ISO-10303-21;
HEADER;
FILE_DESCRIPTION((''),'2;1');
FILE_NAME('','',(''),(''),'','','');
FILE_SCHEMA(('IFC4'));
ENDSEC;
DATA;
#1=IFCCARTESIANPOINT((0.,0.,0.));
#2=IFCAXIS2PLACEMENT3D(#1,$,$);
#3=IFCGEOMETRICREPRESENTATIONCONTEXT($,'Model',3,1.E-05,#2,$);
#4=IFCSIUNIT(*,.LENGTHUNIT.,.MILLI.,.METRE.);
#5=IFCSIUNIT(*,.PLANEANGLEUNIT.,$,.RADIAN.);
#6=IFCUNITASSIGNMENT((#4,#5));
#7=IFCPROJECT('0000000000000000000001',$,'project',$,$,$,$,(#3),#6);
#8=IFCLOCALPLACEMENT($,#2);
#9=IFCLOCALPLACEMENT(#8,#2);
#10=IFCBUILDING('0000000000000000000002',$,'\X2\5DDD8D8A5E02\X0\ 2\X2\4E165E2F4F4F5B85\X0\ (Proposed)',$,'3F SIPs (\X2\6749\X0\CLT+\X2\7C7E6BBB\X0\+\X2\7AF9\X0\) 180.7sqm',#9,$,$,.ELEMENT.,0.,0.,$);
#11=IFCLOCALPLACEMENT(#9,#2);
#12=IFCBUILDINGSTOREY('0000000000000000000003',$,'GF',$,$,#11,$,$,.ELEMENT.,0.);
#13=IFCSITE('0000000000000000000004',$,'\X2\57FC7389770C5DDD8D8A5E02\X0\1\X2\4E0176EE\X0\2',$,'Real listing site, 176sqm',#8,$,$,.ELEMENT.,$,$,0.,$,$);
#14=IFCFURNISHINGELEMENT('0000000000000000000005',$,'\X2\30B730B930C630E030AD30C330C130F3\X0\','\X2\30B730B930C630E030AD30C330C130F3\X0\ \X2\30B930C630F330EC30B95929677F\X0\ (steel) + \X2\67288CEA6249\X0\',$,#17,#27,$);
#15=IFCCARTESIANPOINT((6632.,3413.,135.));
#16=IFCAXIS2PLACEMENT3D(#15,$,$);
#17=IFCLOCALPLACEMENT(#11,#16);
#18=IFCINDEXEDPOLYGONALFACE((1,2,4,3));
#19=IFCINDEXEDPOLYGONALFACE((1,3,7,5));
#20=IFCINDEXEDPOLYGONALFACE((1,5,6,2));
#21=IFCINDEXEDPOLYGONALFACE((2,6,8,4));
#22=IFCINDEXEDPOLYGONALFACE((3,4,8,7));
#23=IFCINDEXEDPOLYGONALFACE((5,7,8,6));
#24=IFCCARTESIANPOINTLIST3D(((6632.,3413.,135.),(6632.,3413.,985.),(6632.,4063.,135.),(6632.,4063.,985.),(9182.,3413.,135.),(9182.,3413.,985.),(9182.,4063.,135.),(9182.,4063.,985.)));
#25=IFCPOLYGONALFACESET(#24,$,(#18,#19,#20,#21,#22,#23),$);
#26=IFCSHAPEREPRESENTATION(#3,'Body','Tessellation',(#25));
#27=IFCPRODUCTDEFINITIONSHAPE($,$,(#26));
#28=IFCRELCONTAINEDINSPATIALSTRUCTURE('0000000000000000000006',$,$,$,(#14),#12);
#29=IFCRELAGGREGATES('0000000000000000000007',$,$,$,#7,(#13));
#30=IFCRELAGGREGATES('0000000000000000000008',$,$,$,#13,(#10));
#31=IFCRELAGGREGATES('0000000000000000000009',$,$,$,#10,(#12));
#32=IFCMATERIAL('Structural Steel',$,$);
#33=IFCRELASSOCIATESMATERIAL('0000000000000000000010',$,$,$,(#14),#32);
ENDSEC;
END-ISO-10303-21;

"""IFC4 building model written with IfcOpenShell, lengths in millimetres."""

from ifc_helpers import new_model, si_unit, frame, frame_2d, origin, place, context, project, spatial, rectangle, extrude, material, element, save


model = new_model("IFC4")

# Units and contexts
model_context = context("Model", 3, precision=1e-05, world=origin())
ifc_project = project(units=[si_unit("LENGTHUNIT", "METRE", prefix="MILLI"), si_unit("PLANEANGLEUNIT", "RADIAN")], contexts=[model_context])

# Site, building, storey
site_placement = place(None, origin())
site = spatial("IfcSite", under=ifc_project, at=site_placement, Name="埼玉県川越市1丁目2", ObjectType="Real listing site, 176sqm", CompositionType="ELEMENT", RefElevation=0.0)
building_placement = place(site_placement, origin())
building = spatial("IfcBuilding", under=site, at=building_placement, Name="川越市 2世帯住宅 (Proposed)", ObjectType="3F SIPs (杉CLT+籾殻+竹) 180.7sqm", CompositionType="ELEMENT", ElevationOfRefHeight=0.0, ElevationOfTerrain=0.0)
storey_placement = place(building_placement, origin())
storey = spatial("IfcBuildingStorey", under=building, at=storey_placement, Name="GF", CompositionType="ELEMENT", Elevation=0.0)

# Furnishing element
ifc_material_1 = material(Name="Structural Steel")
furnishing_1_placement = place(storey_placement, frame((6632.0, 3413.0, 135.0)))
element("IfcFurnishingElement", 1, at=furnishing_1_placement, inside=storey, material=ifc_material_1, Name="システムキッチン", Description="システムキッチン ステンレス天板 (steel) + 木質扉", context=model_context, shape_type="SweptSolid", body=[
    extrude(rectangle(XDim=2550.0, YDim=650.0, at=frame_2d((1275.0, 325.0))), frame((6632.0, 3413.0, 135.0)), (0.0, 0.0, 1.0), 850.0),
])

save(model, "model.ifc")
